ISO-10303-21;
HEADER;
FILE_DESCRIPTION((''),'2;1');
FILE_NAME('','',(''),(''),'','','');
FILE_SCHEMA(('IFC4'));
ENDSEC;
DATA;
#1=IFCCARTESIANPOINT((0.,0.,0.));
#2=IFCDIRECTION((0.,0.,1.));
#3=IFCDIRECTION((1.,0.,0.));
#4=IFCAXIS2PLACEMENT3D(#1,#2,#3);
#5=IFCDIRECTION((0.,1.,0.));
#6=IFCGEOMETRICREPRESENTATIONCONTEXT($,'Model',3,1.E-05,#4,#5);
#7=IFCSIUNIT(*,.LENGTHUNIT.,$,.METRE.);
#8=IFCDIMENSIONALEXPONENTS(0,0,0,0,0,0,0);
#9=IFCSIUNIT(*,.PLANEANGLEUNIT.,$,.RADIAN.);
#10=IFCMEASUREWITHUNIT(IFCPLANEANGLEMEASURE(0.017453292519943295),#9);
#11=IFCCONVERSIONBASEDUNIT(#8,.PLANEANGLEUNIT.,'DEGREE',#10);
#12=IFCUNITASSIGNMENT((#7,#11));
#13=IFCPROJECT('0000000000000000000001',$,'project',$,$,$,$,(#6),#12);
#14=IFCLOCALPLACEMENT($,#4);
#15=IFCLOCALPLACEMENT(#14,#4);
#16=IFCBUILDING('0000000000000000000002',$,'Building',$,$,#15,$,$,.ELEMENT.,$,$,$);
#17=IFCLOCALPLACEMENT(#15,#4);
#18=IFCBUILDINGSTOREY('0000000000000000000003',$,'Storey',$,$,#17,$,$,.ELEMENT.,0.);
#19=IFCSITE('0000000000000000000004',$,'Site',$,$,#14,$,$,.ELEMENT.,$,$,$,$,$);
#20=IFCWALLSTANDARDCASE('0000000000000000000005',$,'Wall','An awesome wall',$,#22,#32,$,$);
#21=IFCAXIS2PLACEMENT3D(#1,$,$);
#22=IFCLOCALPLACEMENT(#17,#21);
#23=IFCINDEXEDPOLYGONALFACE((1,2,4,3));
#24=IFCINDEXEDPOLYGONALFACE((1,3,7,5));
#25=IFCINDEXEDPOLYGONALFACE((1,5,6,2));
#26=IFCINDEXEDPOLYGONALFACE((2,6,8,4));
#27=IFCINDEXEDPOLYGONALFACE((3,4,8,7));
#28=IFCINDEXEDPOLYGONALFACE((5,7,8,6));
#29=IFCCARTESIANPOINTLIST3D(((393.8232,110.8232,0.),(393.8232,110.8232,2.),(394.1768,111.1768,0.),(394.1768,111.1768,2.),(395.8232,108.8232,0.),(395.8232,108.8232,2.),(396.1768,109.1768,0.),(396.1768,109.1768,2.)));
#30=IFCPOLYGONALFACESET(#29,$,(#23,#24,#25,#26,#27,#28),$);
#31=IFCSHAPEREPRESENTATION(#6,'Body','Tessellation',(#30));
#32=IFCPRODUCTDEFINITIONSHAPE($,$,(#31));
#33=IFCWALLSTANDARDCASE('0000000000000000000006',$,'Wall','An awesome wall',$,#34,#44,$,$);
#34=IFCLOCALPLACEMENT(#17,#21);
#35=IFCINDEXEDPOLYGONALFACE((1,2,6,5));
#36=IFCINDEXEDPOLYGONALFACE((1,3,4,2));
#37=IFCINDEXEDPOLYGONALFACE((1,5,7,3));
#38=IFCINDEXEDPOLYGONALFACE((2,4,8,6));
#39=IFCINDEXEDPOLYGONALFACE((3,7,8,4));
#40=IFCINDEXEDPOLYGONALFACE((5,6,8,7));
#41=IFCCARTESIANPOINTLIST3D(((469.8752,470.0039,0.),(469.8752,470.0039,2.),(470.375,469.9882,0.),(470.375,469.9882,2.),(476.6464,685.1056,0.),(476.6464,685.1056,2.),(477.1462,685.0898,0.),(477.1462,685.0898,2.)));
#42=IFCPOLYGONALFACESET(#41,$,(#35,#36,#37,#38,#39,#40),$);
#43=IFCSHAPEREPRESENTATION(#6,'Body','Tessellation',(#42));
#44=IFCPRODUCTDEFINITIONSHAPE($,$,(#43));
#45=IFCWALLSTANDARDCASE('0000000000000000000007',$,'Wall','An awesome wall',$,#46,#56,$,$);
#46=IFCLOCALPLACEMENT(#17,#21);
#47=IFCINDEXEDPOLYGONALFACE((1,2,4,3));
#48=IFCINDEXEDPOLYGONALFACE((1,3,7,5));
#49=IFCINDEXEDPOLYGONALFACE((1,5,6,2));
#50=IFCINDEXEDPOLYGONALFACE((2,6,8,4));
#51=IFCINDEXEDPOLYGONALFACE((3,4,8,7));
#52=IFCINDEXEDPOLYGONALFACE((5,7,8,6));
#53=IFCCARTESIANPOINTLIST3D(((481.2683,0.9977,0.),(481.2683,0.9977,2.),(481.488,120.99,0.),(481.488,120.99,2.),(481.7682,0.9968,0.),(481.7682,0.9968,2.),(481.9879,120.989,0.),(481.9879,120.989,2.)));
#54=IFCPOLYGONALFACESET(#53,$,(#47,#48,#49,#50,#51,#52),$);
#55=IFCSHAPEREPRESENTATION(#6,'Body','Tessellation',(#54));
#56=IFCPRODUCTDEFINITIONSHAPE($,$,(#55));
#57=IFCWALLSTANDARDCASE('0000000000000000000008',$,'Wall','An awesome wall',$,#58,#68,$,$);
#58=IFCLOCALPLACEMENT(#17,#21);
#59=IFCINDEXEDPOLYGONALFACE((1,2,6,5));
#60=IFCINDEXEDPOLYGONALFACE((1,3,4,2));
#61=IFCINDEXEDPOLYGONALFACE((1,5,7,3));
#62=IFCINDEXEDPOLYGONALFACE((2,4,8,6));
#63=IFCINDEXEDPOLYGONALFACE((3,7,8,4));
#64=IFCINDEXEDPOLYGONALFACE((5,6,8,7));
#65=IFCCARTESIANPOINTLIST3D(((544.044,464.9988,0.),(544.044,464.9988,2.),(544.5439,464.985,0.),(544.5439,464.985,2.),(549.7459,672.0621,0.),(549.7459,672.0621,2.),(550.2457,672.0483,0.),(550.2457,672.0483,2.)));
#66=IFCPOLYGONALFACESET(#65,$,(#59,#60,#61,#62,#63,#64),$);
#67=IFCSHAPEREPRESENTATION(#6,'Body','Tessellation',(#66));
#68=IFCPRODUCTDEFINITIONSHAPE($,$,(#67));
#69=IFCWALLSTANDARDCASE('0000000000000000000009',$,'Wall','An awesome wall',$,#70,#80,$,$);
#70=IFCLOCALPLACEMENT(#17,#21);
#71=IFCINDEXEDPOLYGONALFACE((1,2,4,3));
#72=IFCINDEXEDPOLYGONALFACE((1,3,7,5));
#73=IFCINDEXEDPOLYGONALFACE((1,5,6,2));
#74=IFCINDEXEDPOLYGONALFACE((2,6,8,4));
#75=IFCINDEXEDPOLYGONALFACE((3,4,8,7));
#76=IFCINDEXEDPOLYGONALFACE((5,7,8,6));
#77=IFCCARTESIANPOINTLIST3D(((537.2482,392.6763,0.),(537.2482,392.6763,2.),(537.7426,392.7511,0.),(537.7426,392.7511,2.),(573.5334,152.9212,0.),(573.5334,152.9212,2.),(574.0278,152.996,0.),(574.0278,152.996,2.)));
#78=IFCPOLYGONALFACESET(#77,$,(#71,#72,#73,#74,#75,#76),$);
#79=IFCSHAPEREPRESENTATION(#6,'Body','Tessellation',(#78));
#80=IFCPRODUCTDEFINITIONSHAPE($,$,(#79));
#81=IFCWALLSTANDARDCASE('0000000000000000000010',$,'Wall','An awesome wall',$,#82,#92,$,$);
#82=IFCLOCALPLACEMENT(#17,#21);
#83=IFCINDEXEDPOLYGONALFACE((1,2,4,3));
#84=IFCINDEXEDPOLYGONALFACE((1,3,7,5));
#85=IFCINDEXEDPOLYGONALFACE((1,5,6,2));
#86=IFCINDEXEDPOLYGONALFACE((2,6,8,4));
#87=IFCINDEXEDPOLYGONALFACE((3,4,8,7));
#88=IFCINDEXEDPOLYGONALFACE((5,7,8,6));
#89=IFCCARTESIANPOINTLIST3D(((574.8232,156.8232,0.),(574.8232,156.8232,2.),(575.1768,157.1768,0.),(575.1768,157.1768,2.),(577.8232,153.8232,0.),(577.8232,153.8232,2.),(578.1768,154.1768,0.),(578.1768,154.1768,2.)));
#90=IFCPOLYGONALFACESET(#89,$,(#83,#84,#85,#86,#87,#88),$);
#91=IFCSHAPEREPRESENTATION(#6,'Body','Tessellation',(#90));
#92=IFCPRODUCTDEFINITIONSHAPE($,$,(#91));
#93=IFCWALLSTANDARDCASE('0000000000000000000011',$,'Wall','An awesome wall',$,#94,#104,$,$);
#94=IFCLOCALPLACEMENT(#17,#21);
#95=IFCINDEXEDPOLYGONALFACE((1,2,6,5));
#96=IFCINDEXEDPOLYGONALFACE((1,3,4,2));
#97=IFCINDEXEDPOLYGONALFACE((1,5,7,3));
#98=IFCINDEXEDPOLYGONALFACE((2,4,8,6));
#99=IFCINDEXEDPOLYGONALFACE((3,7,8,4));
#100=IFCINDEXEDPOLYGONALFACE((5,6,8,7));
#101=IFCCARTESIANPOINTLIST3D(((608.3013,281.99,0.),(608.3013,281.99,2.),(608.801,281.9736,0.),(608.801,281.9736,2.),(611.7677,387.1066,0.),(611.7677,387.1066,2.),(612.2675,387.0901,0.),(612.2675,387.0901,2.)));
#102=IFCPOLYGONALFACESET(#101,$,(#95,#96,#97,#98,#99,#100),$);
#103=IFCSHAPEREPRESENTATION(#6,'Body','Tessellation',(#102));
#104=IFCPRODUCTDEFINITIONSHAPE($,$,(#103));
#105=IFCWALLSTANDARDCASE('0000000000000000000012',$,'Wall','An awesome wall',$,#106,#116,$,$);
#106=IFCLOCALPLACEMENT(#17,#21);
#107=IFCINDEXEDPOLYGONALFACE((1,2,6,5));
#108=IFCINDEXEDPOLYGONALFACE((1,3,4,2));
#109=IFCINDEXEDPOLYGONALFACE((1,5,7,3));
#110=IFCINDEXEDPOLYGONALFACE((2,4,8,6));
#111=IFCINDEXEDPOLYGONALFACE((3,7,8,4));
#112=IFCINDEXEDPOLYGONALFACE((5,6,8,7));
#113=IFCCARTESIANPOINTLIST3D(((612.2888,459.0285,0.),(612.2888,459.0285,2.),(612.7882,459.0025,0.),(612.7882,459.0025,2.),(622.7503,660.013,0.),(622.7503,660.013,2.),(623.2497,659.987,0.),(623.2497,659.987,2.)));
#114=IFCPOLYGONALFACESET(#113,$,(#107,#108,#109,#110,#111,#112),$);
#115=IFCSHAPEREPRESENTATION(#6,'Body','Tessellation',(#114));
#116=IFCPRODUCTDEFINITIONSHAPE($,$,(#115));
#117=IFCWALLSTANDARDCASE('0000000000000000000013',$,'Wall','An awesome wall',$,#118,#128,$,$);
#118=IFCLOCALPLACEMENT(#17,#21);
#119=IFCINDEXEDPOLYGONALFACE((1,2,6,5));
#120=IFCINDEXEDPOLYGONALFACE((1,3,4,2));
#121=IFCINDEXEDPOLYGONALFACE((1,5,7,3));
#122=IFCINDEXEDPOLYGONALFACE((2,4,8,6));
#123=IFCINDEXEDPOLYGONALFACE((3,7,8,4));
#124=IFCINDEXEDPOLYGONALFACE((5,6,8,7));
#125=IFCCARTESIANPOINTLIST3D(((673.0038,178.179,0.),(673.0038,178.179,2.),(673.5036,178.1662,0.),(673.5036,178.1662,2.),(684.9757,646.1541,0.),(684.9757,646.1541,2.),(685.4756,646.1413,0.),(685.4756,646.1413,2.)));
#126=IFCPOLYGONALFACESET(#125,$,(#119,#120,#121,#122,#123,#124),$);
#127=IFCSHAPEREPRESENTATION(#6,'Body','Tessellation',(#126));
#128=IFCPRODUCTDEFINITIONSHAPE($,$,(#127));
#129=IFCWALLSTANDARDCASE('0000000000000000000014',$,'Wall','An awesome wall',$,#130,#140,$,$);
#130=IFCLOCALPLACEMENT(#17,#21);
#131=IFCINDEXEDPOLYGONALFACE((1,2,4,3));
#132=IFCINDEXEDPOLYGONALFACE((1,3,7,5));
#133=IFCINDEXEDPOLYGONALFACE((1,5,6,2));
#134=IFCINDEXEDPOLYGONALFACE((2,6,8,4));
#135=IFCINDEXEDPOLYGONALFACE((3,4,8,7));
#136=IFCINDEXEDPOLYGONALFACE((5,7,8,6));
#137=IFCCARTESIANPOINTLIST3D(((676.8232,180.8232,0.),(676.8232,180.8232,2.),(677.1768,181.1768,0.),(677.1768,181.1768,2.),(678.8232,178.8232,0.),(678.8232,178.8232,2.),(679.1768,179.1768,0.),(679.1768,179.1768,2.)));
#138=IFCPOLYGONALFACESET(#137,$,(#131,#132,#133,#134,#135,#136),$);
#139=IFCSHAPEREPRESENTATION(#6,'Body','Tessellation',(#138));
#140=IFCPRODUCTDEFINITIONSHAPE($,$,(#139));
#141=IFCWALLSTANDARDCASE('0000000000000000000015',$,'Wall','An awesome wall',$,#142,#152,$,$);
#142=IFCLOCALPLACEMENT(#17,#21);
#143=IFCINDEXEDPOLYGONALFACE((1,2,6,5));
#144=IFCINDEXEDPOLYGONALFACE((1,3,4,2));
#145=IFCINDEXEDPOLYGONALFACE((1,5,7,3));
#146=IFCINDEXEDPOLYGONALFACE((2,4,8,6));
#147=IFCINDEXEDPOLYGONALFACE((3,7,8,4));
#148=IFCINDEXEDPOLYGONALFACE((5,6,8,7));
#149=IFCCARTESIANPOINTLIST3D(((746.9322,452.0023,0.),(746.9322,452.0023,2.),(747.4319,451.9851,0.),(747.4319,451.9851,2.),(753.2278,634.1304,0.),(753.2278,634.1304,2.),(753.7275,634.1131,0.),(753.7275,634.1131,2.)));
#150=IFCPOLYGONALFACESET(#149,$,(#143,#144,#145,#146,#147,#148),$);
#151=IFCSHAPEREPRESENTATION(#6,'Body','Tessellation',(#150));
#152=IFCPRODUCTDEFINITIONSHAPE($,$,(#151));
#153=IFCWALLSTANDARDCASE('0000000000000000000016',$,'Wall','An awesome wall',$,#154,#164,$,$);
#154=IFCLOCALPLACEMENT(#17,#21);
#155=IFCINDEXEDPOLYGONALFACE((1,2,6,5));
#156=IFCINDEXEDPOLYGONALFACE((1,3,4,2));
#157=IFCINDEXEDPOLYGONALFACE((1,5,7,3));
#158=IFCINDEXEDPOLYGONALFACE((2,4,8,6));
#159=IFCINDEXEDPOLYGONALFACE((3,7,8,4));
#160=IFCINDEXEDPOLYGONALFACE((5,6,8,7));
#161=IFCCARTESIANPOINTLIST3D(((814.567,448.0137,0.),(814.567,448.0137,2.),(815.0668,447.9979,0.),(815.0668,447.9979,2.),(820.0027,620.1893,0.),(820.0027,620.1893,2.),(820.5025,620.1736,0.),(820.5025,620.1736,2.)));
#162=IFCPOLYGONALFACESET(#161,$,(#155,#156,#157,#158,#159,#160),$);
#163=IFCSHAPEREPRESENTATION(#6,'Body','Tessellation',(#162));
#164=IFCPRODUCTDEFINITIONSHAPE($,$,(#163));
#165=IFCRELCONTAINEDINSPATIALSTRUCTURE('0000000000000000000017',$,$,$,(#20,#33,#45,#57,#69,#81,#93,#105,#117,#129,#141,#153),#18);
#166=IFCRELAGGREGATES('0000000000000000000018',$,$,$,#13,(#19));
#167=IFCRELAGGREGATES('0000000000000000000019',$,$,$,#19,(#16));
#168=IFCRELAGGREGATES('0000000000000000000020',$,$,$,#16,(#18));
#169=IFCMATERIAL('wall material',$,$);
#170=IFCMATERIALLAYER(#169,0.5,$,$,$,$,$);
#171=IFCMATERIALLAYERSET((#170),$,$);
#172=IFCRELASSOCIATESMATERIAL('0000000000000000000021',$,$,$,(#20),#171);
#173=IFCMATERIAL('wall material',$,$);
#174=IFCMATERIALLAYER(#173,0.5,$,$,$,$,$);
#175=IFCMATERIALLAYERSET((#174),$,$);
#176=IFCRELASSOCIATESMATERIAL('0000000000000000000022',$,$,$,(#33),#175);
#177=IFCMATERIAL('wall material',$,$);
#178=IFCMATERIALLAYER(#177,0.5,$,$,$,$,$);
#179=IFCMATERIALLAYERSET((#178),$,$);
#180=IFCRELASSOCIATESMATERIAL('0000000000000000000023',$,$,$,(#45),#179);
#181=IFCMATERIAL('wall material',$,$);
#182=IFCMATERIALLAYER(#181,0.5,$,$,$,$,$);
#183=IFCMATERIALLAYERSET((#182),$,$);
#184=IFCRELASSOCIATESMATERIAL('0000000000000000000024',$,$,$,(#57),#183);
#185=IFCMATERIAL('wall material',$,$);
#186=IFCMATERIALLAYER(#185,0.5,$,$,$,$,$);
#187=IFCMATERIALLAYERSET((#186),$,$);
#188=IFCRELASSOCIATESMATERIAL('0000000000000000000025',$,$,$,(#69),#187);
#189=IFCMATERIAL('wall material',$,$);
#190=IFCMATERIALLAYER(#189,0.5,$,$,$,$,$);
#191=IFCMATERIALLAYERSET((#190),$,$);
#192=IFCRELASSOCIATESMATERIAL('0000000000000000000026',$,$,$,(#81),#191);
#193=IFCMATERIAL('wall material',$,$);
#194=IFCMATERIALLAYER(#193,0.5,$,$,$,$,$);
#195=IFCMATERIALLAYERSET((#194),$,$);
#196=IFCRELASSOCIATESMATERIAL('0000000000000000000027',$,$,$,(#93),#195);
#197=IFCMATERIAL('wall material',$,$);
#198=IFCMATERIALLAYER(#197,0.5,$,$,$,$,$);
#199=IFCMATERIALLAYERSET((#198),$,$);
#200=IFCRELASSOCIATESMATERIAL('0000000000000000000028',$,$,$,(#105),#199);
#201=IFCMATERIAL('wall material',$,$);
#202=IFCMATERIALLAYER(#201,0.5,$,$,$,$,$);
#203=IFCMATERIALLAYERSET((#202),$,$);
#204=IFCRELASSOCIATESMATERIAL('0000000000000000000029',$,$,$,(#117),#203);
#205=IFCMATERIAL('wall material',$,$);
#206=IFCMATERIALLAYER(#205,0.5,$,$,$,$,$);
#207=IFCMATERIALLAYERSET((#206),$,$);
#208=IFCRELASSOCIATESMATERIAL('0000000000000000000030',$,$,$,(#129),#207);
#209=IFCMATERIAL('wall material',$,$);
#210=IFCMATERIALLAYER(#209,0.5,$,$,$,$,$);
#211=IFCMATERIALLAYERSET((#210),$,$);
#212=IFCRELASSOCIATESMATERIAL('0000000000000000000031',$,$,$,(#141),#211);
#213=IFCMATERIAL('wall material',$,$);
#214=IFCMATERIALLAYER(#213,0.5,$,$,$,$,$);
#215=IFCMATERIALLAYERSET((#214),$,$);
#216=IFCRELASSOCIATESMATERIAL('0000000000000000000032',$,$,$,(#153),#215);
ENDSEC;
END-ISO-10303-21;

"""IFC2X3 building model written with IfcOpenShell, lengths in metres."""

from ifc_helpers import new_model, entity, si_unit, converted_unit, direction, frame, origin_with_axes, place, context, project, spatial, polyline, outline, extrude, material, layer, layer_set, layer_usage, element, save


model = new_model("IFC2X3")

# Units and contexts
model_context = context("Model", 3, precision=1e-05, world=origin_with_axes(), true_north=direction((0.0, 1.0, 0.0)))
ifc_project = project(units=[si_unit("LENGTHUNIT", "METRE"), converted_unit("PLANEANGLEUNIT", "DEGREE", entity("IfcPlaneAngleMeasure", 0.017453292519943295), si_unit("PLANEANGLEUNIT", "RADIAN"), dimensions=[0, 0, 0, 0, 0, 0, 0])], contexts=[model_context])

# Site, building, storey
site_placement = place(None, origin_with_axes())
site = spatial("IfcSite", under=ifc_project, at=site_placement, Name="Site", CompositionType="ELEMENT")
building_placement = place(site_placement, origin_with_axes())
building = spatial("IfcBuilding", under=site, at=building_placement, Name="Building", CompositionType="ELEMENT")
storey_placement = place(building_placement, origin_with_axes())
storey = spatial("IfcBuildingStorey", under=building, at=storey_placement, Name="Storey", CompositionType="ELEMENT", Elevation=0.0)

# Walls
ifc_material_1 = material(Name="wall material")
ifc_layer_1 = layer(ifc_material_1, 0.5)
ifc_layer_set_1 = layer_set([ifc_layer_1])
ifc_layer_usage_1 = layer_usage(ifc_layer_set_1, "AXIS2", "POSITIVE", -0.1)
wall_1_placement = place(storey_placement, origin_with_axes())
element("IfcWallStandardCase", 1, at=wall_1_placement, inside=storey, material=ifc_layer_usage_1, Name="Wall", Description="An awesome wall", context=model_context, shape_type="SweptSolid", body=[
    extrude(outline(polyline([(0.0, -0.25, 0.0), (2.8284, -0.25, 0.0), (2.8284, 0.25, 0.0), (0.0, 0.25, 0.0), (0.0, -0.25, 0.0)])), frame((396.0, 109.0, 0.0), z_axis=(0.0, 0.0, 1.0), x_axis=(-2.0, 2.00002, 0.0)), (0.0, 0.0, 1.0), 2.0),
])
ifc_material_2 = material(Name="wall material")
ifc_layer_2 = layer(ifc_material_2, 0.5)
ifc_layer_set_2 = layer_set([ifc_layer_2])
ifc_layer_usage_2 = layer_usage(ifc_layer_set_2, "AXIS2", "POSITIVE", -0.1)
wall_2_placement = place(storey_placement, origin_with_axes())
element("IfcWallStandardCase", 2, at=wall_2_placement, inside=storey, material=ifc_layer_usage_2, Name="Wall", Description="An awesome wall", context=model_context, shape_type="SweptSolid", body=[
    extrude(outline(polyline([(0.0, -0.25, 0.0), (215.2082, -0.25, 0.0), (215.2082, 0.25, 0.0), (0.0, 0.25, 0.0), (0.0, -0.25, 0.0)])), frame((470.1251, 469.9961, 0.0), z_axis=(0.0, 0.0, 1.0), x_axis=(6.77118, 215.10164, 0.0)), (0.0, 0.0, 1.0), 2.0),
])
ifc_material_3 = material(Name="wall material")
ifc_layer_3 = layer(ifc_material_3, 0.5)
ifc_layer_set_3 = layer_set([ifc_layer_3])
ifc_layer_usage_3 = layer_usage(ifc_layer_set_3, "AXIS2", "POSITIVE", -0.1)
wall_3_placement = place(storey_placement, origin_with_axes())
element("IfcWallStandardCase", 3, at=wall_3_placement, inside=storey, material=ifc_layer_usage_3, Name="Wall", Description="An awesome wall", context=model_context, shape_type="SweptSolid", body=[
    extrude(outline(polyline([(0.0, -0.25, 0.0), (119.9925, -0.25, 0.0), (119.9925, 0.25, 0.0), (0.0, 0.25, 0.0), (0.0, -0.25, 0.0)])), frame((481.5183, 0.9972, 0.0), z_axis=(0.0, 0.0, 1.0), x_axis=(0.2197, 119.992274, 0.0)), (0.0, 0.0, 1.0), 2.0),
])
ifc_material_4 = material(Name="wall material")
ifc_layer_4 = layer(ifc_material_4, 0.5)
ifc_layer_set_4 = layer_set([ifc_layer_4])
ifc_layer_usage_4 = layer_usage(ifc_layer_set_4, "AXIS2", "POSITIVE", -0.1)
wall_4_placement = place(storey_placement, origin_with_axes())
element("IfcWallStandardCase", 4, at=wall_4_placement, inside=storey, material=ifc_layer_usage_4, Name="Wall", Description="An awesome wall", context=model_context, shape_type="SweptSolid", body=[
    extrude(outline(polyline([(0.0, -0.25, 0.0), (207.1418, -0.25, 0.0), (207.1418, 0.25, 0.0), (0.0, 0.25, 0.0), (0.0, -0.25, 0.0)])), frame((544.2939, 464.9919, 0.0), z_axis=(0.0, 0.0, 1.0), x_axis=(5.70185, 207.0633, 0.0)), (0.0, 0.0, 1.0), 2.0),
])
ifc_material_5 = material(Name="wall material")
ifc_layer_5 = layer(ifc_material_5, 0.5)
ifc_layer_set_5 = layer_set([ifc_layer_5])
ifc_layer_usage_5 = layer_usage(ifc_layer_set_5, "AXIS2", "POSITIVE", -0.1)
wall_5_placement = place(storey_placement, origin_with_axes())
element("IfcWallStandardCase", 5, at=wall_5_placement, inside=storey, material=ifc_layer_usage_5, Name="Wall", Description="An awesome wall", context=model_context, shape_type="SweptSolid", body=[
    extrude(outline(polyline([(0.0, -0.25, 0.0), (242.4853, -0.25, 0.0), (242.4853, 0.25, 0.0), (0.0, 0.25, 0.0), (0.0, -0.25, 0.0)])), frame((537.4954, 392.7137, 0.0), z_axis=(0.0, 0.0, 1.0), x_axis=(36.2852, -239.75509, 0.0)), (0.0, 0.0, 1.0), 2.0),
])
ifc_material_6 = material(Name="wall material")
ifc_layer_6 = layer(ifc_material_6, 0.5)
ifc_layer_set_6 = layer_set([ifc_layer_6])
ifc_layer_usage_6 = layer_usage(ifc_layer_set_6, "AXIS2", "POSITIVE", -0.1)
wall_6_placement = place(storey_placement, origin_with_axes())
element("IfcWallStandardCase", 6, at=wall_6_placement, inside=storey, material=ifc_layer_usage_6, Name="Wall", Description="An awesome wall", context=model_context, shape_type="SweptSolid", body=[
    extrude(outline(polyline([(0.0, -0.25, 0.0), (4.2427, -0.25, 0.0), (4.2427, 0.25, 0.0), (0.0, 0.25, 0.0), (0.0, -0.25, 0.0)])), frame((578.0, 154.0, 0.0), z_axis=(0.0, 0.0, 1.0), x_axis=(-3.0, 3.00004, 0.0)), (0.0, 0.0, 1.0), 2.0),
])
ifc_material_7 = material(Name="wall material")
ifc_layer_7 = layer(ifc_material_7, 0.5)
ifc_layer_set_7 = layer_set([ifc_layer_7])
ifc_layer_usage_7 = layer_usage(ifc_layer_set_7, "AXIS2", "POSITIVE", -0.1)
wall_7_placement = place(storey_placement, origin_with_axes())
element("IfcWallStandardCase", 7, at=wall_7_placement, inside=storey, material=ifc_layer_usage_7, Name="Wall", Description="An awesome wall", context=model_context, shape_type="SweptSolid", body=[
    extrude(outline(polyline([(0.0, -0.25, 0.0), (105.1737, -0.25, 0.0), (105.1737, 0.25, 0.0), (0.0, 0.25, 0.0), (0.0, -0.25, 0.0)])), frame((608.5512, 281.9818, 0.0), z_axis=(0.0, 0.0, 1.0), x_axis=(3.46645, 105.11656, 0.0)), (0.0, 0.0, 1.0), 2.0),
])
ifc_material_8 = material(Name="wall material")
ifc_layer_8 = layer(ifc_material_8, 0.5)
ifc_layer_set_8 = layer_set([ifc_layer_8])
ifc_layer_usage_8 = layer_usage(ifc_layer_set_8, "AXIS2", "POSITIVE", -0.1)
wall_8_placement = place(storey_placement, origin_with_axes())
element("IfcWallStandardCase", 8, at=wall_8_placement, inside=storey, material=ifc_layer_usage_8, Name="Wall", Description="An awesome wall", context=model_context, shape_type="SweptSolid", body=[
    extrude(outline(polyline([(0.0, -0.25, 0.0), (201.2566, -0.25, 0.0), (201.2566, 0.25, 0.0), (0.0, 0.25, 0.0), (0.0, -0.25, 0.0)])), frame((612.5385, 459.0155, 0.0), z_axis=(0.0, 0.0, 1.0), x_axis=(10.4615, 200.9845, 0.0)), (0.0, 0.0, 1.0), 2.0),
])
ifc_material_9 = material(Name="wall material")
ifc_layer_9 = layer(ifc_material_9, 0.5)
ifc_layer_set_9 = layer_set([ifc_layer_9])
ifc_layer_usage_9 = layer_usage(ifc_layer_set_9, "AXIS2", "POSITIVE", -0.1)
wall_9_placement = place(storey_placement, origin_with_axes())
element("IfcWallStandardCase", 9, at=wall_9_placement, inside=storey, material=ifc_layer_usage_9, Name="Wall", Description="An awesome wall", context=model_context, shape_type="SweptSolid", body=[
    extrude(outline(polyline([(0.0, -0.25, 0.0), (468.1282, -0.25, 0.0), (468.1282, 0.25, 0.0), (0.0, 0.25, 0.0), (0.0, -0.25, 0.0)])), frame((673.2537, 178.1726, 0.0), z_axis=(0.0, 0.0, 1.0), x_axis=(11.97195, 467.97511, 0.0)), (0.0, 0.0, 1.0), 2.0),
])
ifc_material_10 = material(Name="wall material")
ifc_layer_10 = layer(ifc_material_10, 0.5)
ifc_layer_set_10 = layer_set([ifc_layer_10])
ifc_layer_usage_10 = layer_usage(ifc_layer_set_10, "AXIS2", "POSITIVE", -0.1)
wall_10_placement = place(storey_placement, origin_with_axes())
element("IfcWallStandardCase", 10, at=wall_10_placement, inside=storey, material=ifc_layer_usage_10, Name="Wall", Description="An awesome wall", context=model_context, shape_type="SweptSolid", body=[
    extrude(outline(polyline([(0.0, -0.25, 0.0), (2.8285, -0.25, 0.0), (2.8285, 0.25, 0.0), (0.0, 0.25, 0.0), (0.0, -0.25, 0.0)])), frame((679.0, 179.0, 0.0), z_axis=(0.0, 0.0, 1.0), x_axis=(-2.0, 2.00004, 0.0)), (0.0, 0.0, 1.0), 2.0),
])
ifc_material_11 = material(Name="wall material")
ifc_layer_11 = layer(ifc_material_11, 0.5)
ifc_layer_set_11 = layer_set([ifc_layer_11])
ifc_layer_usage_11 = layer_usage(ifc_layer_set_11, "AXIS2", "POSITIVE", -0.1)
wall_11_placement = place(storey_placement, origin_with_axes())
element("IfcWallStandardCase", 11, at=wall_11_placement, inside=storey, material=ifc_layer_usage_11, Name="Wall", Description="An awesome wall", context=model_context, shape_type="SweptSolid", body=[
    extrude(outline(polyline([(0.0, -0.25, 0.0), (182.2368, -0.25, 0.0), (182.2368, 0.25, 0.0), (0.0, 0.25, 0.0), (0.0, -0.25, 0.0)])), frame((747.1821, 451.9937, 0.0), z_axis=(0.0, 0.0, 1.0), x_axis=(6.29559, 182.12807, 0.0)), (0.0, 0.0, 1.0), 2.0),
])
ifc_material_12 = material(Name="wall material")
ifc_layer_12 = layer(ifc_material_12, 0.5)
ifc_layer_set_12 = layer_set([ifc_layer_12])
ifc_layer_usage_12 = layer_usage(ifc_layer_set_12, "AXIS2", "POSITIVE", -0.1)
wall_12_placement = place(storey_placement, origin_with_axes())
element("IfcWallStandardCase", 12, at=wall_12_placement, inside=storey, material=ifc_layer_usage_12, Name="Wall", Description="An awesome wall", context=model_context, shape_type="SweptSolid", body=[
    extrude(outline(polyline([(0.0, -0.25, 0.0), (172.2615, -0.25, 0.0), (172.2615, 0.25, 0.0), (0.0, 0.25, 0.0), (0.0, -0.25, 0.0)])), frame((814.8169, 448.0058, 0.0), z_axis=(0.0, 0.0, 1.0), x_axis=(5.4357, 172.17569, 0.0)), (0.0, 0.0, 1.0), 2.0),
])

save(model, "model.ifc")
